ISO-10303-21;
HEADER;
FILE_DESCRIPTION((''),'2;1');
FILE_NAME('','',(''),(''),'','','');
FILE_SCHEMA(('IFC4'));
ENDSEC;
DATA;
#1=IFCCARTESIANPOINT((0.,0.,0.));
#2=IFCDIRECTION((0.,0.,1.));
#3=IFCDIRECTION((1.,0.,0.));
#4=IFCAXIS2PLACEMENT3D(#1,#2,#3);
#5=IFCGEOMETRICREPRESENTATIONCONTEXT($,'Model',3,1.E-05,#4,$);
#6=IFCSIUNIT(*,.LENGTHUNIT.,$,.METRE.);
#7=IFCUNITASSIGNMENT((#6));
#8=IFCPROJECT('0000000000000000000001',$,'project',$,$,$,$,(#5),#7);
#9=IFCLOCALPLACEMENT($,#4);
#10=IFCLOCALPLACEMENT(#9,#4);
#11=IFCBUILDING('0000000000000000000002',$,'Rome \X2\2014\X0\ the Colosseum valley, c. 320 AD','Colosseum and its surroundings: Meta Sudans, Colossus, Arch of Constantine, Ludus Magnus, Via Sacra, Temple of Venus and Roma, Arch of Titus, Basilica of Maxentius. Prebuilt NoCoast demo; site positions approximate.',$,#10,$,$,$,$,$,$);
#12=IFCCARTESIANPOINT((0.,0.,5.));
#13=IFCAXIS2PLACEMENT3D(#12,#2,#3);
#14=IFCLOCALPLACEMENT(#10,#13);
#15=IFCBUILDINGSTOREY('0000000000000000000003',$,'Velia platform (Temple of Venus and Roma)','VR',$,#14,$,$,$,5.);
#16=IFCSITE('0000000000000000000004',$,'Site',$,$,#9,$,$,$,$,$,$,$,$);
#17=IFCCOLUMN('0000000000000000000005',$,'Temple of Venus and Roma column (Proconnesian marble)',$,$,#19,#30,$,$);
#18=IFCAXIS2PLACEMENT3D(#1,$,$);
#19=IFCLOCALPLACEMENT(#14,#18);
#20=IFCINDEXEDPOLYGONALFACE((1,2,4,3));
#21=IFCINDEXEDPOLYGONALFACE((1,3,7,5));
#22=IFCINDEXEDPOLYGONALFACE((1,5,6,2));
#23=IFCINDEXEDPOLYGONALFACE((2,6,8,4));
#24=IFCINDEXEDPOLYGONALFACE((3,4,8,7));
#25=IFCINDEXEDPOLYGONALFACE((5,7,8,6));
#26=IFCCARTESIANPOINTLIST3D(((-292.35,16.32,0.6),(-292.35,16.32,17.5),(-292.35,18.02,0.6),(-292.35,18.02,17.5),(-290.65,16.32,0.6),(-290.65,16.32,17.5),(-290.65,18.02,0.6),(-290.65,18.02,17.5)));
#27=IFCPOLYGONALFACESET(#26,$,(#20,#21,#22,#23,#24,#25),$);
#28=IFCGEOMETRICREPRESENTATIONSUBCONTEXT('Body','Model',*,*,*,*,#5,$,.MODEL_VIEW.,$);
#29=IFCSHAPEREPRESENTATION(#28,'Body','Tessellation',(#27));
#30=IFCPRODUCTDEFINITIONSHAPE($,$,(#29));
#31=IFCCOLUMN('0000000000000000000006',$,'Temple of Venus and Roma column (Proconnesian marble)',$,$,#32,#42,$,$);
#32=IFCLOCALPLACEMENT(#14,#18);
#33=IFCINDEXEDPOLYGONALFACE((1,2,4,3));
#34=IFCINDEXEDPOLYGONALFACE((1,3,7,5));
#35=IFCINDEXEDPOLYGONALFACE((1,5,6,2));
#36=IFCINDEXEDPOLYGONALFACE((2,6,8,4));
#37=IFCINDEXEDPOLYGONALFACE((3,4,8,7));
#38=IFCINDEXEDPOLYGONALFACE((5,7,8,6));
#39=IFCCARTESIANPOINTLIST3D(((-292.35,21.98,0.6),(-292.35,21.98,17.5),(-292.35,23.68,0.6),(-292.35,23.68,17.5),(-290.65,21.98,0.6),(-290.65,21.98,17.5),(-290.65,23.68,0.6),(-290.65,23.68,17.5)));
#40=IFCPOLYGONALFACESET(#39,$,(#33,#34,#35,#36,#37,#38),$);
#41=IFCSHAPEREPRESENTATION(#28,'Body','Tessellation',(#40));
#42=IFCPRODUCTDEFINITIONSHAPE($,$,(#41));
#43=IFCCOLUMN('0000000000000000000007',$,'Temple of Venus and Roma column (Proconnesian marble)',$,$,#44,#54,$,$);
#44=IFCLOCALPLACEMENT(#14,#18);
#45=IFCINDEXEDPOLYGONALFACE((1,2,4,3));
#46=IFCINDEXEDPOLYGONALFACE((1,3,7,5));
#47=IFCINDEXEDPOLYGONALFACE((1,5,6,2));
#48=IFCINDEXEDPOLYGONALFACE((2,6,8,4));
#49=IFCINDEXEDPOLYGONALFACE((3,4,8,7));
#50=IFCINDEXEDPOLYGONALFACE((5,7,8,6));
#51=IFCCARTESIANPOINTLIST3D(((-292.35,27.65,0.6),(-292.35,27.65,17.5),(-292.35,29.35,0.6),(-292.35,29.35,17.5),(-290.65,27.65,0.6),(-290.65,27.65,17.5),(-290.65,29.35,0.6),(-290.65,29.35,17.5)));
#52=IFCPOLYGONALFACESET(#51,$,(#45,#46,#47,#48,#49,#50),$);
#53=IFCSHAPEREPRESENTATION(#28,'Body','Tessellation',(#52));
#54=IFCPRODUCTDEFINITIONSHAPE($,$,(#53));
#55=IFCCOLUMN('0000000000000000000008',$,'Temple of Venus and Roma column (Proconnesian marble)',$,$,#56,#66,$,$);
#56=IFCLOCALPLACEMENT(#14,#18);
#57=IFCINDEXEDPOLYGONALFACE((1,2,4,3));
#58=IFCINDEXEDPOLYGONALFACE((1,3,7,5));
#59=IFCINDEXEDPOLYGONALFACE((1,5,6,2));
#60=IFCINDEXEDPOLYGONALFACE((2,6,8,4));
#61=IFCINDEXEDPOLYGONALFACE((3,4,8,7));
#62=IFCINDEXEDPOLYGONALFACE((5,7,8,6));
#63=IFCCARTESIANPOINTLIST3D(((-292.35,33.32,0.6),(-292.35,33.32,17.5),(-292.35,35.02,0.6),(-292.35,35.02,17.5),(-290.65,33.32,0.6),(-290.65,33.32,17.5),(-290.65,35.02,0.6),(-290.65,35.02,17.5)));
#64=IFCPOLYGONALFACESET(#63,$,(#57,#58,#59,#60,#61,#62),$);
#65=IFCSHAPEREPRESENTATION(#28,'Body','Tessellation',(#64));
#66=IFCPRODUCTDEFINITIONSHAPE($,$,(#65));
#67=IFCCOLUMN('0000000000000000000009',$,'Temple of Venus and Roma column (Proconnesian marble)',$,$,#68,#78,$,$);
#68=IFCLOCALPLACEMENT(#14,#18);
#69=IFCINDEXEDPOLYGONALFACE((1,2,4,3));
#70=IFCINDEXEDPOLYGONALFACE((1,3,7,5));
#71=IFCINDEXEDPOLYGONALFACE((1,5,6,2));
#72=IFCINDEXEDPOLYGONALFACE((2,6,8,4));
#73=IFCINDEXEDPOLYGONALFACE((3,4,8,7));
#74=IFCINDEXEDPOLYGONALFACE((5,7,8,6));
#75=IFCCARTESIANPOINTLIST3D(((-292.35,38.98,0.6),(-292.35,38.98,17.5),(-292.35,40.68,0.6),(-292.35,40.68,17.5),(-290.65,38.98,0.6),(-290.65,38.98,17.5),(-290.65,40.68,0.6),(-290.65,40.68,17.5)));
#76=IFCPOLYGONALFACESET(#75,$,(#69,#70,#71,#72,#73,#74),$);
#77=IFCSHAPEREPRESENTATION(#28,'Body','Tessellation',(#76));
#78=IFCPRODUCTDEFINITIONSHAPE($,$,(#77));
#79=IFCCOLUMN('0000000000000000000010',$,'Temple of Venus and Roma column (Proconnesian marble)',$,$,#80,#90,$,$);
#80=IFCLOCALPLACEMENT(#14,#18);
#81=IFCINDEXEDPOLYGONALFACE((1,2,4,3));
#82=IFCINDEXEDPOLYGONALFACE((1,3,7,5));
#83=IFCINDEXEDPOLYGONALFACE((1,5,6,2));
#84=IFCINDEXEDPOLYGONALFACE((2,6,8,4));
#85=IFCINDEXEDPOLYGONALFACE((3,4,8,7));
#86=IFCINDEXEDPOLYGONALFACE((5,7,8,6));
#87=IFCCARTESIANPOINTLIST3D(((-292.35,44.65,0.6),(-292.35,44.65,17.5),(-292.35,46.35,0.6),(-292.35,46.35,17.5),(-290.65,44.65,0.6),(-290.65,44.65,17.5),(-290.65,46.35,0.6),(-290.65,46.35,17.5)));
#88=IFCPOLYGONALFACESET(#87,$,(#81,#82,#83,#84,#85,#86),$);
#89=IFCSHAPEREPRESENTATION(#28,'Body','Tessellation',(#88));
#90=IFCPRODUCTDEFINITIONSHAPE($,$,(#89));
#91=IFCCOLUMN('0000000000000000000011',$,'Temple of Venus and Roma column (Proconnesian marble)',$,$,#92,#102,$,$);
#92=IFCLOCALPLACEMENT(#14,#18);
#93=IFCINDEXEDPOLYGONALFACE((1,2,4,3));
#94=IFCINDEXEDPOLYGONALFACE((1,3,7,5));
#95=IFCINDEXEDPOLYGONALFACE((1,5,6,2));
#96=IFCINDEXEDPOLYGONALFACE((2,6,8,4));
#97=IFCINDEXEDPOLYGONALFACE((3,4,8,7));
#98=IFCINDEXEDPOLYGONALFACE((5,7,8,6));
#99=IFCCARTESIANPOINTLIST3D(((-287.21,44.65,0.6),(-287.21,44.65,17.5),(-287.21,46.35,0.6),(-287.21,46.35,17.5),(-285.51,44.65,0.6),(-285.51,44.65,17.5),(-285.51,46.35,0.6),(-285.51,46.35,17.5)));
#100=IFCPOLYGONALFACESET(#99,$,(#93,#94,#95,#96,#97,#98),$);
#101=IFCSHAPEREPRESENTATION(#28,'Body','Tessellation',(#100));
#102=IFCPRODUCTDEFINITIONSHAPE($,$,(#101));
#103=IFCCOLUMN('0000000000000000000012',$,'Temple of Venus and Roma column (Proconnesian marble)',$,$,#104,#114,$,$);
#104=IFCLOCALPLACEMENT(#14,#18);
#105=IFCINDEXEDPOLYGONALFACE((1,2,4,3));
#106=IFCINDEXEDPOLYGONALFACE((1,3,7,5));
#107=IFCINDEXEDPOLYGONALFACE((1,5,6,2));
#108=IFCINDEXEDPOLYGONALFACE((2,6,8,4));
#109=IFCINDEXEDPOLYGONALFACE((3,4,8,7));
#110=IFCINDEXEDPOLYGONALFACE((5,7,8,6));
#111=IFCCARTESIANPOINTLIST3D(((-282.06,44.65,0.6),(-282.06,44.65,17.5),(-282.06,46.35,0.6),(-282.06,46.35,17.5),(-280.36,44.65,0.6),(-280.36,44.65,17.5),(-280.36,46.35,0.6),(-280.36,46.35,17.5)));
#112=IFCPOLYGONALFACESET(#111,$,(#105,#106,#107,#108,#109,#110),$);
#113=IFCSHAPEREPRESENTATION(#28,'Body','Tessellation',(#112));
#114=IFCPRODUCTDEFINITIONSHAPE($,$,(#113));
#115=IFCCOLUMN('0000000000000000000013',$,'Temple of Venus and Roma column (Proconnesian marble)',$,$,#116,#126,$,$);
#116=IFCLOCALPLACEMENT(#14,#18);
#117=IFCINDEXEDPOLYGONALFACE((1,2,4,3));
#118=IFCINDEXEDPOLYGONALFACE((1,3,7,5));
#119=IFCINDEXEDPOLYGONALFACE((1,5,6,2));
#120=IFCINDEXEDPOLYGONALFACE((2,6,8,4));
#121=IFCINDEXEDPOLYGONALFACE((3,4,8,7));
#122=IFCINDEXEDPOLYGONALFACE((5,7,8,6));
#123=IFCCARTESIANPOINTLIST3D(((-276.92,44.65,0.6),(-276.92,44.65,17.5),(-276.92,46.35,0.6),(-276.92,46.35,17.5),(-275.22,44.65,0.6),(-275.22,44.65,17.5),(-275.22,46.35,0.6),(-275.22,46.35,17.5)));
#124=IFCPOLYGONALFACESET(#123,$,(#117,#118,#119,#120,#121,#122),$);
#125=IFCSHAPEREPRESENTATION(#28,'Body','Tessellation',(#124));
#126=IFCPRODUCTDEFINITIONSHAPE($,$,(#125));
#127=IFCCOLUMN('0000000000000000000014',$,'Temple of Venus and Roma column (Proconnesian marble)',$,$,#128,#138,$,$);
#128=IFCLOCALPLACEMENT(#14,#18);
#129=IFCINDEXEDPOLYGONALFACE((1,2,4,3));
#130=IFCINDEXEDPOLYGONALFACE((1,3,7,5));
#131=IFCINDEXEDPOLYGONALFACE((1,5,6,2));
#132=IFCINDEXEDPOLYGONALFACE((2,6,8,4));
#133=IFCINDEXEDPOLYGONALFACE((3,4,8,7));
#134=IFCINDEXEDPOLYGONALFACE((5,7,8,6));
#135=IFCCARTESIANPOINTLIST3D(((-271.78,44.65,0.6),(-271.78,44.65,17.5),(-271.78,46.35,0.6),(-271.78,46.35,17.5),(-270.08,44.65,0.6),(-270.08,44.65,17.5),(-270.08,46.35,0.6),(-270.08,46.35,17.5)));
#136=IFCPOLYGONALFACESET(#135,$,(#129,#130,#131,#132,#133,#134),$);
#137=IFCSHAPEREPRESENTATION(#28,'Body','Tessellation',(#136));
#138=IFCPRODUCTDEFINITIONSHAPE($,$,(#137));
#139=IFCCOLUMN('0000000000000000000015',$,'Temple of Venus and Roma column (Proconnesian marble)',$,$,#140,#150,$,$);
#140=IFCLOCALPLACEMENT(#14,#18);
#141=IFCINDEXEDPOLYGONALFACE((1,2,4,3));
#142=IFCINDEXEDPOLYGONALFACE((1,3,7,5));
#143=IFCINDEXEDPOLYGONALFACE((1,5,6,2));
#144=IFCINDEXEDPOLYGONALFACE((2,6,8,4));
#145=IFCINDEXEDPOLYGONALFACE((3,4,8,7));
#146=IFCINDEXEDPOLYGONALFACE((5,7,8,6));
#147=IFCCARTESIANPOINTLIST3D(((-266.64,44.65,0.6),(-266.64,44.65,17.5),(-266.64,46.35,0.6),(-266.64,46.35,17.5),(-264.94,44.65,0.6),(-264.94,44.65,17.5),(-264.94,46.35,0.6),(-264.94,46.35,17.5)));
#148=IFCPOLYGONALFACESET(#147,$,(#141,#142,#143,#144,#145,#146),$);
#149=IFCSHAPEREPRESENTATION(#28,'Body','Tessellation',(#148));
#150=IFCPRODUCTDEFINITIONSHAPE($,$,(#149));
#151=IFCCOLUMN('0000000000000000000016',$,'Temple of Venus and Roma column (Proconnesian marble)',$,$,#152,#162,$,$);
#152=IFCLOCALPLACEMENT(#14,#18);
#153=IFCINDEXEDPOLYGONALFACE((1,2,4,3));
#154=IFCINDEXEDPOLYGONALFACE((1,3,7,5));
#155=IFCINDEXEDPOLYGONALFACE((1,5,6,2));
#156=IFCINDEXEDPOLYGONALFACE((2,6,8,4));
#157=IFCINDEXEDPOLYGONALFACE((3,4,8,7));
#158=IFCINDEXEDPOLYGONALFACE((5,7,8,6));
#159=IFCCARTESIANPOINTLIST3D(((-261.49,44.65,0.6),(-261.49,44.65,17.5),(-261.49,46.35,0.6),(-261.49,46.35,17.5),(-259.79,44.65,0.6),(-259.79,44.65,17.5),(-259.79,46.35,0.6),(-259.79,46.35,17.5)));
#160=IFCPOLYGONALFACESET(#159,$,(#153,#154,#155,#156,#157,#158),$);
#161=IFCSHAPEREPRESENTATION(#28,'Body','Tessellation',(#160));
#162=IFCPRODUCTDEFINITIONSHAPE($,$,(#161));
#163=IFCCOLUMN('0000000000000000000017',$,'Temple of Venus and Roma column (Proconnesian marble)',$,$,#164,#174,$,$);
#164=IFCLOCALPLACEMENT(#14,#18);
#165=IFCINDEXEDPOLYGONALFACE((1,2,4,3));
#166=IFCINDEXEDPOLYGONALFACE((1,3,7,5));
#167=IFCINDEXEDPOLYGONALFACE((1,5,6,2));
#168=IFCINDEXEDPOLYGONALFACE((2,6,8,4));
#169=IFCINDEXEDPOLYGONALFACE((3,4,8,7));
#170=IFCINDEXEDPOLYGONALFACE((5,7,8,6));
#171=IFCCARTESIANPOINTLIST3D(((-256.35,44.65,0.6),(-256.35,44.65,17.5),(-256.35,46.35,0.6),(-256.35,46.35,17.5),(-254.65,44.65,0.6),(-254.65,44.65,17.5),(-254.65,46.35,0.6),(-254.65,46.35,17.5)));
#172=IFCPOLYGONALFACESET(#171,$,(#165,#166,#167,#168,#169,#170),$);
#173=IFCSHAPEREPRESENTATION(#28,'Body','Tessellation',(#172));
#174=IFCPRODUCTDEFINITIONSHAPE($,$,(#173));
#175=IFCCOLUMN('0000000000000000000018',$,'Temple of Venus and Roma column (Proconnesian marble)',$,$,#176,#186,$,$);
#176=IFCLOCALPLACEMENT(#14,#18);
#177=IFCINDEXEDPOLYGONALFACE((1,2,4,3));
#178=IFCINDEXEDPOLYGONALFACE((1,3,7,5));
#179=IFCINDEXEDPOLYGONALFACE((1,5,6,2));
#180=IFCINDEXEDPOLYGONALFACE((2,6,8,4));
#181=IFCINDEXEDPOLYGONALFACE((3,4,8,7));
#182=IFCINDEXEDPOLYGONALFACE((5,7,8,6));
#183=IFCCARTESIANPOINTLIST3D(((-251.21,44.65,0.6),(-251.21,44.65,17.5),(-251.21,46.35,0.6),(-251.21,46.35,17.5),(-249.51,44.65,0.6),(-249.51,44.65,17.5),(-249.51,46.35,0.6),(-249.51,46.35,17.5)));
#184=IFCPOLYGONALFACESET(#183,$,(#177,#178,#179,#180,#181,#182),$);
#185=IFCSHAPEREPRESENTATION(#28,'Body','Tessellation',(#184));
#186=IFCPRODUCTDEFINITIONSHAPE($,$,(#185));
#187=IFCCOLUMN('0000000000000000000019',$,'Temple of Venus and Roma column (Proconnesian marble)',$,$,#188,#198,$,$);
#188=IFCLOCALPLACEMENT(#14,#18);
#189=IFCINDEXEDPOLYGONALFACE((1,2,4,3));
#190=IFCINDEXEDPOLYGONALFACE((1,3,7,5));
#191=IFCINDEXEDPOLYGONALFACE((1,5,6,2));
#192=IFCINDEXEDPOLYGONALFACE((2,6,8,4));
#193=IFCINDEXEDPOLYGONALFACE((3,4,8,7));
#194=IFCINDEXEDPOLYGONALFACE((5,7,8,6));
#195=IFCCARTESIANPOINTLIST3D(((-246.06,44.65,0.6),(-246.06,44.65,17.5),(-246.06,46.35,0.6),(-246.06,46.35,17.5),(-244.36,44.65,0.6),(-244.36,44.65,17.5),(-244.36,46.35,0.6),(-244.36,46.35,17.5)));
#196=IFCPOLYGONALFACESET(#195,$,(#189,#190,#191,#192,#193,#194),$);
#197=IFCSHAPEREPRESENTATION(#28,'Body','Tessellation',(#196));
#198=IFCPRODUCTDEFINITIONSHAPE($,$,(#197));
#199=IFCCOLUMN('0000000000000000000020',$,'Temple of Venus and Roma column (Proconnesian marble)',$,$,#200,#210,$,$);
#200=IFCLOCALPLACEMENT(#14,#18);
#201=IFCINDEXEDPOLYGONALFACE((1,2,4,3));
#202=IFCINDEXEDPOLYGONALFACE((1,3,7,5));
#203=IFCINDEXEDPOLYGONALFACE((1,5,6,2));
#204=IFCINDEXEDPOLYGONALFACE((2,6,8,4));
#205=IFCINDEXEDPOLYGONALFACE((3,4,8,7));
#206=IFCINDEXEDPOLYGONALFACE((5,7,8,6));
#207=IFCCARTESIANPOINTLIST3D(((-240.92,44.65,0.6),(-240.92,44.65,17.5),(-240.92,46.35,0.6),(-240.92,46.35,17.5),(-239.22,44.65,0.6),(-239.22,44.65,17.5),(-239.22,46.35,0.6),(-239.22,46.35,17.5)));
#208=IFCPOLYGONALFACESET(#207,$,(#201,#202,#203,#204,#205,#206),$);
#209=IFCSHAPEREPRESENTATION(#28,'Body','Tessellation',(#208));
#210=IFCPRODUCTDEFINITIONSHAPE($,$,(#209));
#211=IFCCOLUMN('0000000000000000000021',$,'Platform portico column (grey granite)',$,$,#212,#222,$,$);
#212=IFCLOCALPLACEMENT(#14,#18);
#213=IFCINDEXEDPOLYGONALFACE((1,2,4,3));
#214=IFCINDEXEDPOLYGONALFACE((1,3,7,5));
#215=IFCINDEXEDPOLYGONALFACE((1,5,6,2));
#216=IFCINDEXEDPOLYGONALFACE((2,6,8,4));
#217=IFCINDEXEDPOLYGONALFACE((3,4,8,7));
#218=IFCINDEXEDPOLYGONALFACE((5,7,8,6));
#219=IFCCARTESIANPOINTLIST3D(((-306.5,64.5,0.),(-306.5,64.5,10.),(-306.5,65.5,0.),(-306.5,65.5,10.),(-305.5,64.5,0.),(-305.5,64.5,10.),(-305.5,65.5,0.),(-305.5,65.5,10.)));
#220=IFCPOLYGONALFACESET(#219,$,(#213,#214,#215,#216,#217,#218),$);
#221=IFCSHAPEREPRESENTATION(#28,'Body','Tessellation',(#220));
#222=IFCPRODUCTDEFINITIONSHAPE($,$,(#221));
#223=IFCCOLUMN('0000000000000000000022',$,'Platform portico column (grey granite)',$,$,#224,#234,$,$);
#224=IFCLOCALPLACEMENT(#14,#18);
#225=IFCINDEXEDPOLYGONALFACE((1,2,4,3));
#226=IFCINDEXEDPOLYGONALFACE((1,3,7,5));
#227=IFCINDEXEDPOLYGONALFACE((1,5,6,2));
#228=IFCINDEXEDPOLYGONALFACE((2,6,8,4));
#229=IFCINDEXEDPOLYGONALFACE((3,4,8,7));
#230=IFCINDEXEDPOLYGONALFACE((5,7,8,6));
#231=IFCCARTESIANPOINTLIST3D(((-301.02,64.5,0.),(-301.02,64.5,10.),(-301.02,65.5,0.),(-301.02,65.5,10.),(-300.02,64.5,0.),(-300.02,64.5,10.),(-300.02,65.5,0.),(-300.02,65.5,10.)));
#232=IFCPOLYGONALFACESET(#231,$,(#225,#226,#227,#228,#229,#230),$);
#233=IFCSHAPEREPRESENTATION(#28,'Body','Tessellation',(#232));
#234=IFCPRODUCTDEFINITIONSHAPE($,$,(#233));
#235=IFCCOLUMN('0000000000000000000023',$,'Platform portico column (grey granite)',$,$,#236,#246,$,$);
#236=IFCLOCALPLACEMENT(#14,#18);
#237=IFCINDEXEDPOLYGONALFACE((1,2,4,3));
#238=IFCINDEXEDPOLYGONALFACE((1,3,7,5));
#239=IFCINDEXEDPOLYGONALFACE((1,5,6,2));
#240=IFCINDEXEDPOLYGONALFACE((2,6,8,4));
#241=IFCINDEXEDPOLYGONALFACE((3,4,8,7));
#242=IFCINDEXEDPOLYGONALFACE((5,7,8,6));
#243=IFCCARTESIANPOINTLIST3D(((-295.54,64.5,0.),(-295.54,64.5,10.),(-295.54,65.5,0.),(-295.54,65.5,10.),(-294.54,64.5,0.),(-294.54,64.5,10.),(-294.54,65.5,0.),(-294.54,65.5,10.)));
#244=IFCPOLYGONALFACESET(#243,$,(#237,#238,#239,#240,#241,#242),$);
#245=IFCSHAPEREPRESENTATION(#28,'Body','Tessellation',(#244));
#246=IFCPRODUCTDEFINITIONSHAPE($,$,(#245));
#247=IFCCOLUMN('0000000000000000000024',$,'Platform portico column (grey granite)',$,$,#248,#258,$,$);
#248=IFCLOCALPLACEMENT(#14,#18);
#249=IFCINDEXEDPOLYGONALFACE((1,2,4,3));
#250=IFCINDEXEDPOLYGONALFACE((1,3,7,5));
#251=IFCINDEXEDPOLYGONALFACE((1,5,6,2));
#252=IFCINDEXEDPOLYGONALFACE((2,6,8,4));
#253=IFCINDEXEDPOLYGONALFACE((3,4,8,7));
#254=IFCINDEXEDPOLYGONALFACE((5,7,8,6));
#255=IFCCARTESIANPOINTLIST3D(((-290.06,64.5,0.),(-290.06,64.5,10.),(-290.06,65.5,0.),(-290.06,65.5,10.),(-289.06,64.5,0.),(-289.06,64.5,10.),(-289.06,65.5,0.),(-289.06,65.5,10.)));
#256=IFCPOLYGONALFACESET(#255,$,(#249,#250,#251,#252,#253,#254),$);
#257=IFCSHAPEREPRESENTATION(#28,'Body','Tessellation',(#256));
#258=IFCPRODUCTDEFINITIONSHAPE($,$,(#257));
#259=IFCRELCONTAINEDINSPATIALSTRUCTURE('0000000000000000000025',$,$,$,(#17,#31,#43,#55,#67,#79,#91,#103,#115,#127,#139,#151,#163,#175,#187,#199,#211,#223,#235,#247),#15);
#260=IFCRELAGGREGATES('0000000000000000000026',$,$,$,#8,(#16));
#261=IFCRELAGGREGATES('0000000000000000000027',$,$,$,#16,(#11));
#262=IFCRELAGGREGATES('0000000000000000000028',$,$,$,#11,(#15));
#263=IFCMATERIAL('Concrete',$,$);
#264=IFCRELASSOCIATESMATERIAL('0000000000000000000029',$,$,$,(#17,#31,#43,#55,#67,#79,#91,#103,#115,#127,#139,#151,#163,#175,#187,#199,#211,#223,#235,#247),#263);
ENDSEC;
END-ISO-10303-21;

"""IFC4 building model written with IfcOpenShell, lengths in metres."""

from ifc_helpers import new_model, si_unit, frame, origin_with_axes, place, context, subcontext, project, spatial, indexed_curve, outline, extrude, material, element, save


model = new_model("IFC4")

# Units and contexts
model_context = context("Model", 3, precision=1e-05, world=origin_with_axes())
body_context = subcontext(model_context, "Body", "Model", "MODEL_VIEW")
ifc_project = project(units=[si_unit("LENGTHUNIT", "METRE")], contexts=[model_context])

# Site, building, storey
site_placement = place(None, origin_with_axes())
site = spatial("IfcSite", under=ifc_project, at=site_placement, Name="Site")
building_placement = place(site_placement, origin_with_axes())
building = spatial("IfcBuilding", under=site, at=building_placement, Name="Rome — the Colosseum valley, c. 320 AD", Description="Colosseum and its surroundings: Meta Sudans, Colossus, Arch of Constantine, Ludus Magnus, Via Sacra, Temple of Venus and Roma, Arch of Titus, Basilica of Maxentius. Prebuilt NoCoast demo; site positions approximate.")
storey_placement = place(building_placement, frame((0.0, 0.0, 5.0), z_axis=(0.0, 0.0, 1.0), x_axis=(1.0, 0.0, 0.0)))
storey = spatial("IfcBuildingStorey", under=building, at=storey_placement, Name="Velia platform (Temple of Venus and Roma)", Description="VR", Elevation=5.0)

# Columns
ifc_material_1 = material(Name="Concrete")
for number, where, z_axis, x_axis, name in (
    (1, (-292.35, 17.17, 0.6), (0.0, 0.0, 1.0), (1.0, 0.0, 0.0), "Temple of Venus and Roma column (Proconnesian marble)"),
    (2, (-292.35, 22.83, 0.6), (0.0, 0.0, 1.0), (1.0, 0.0, 0.0), "Temple of Venus and Roma column (Proconnesian marble)"),
    (3, (-292.35, 28.5, 0.6), (0.0, 0.0, 1.0), (1.0, 0.0, 0.0), "Temple of Venus and Roma column (Proconnesian marble)"),
    (4, (-292.35, 34.17, 0.6), (0.0, 0.0, 1.0), (1.0, 0.0, 0.0), "Temple of Venus and Roma column (Proconnesian marble)"),
    (5, (-292.35, 39.83, 0.6), (0.0, 0.0, 1.0), (1.0, 0.0, 0.0), "Temple of Venus and Roma column (Proconnesian marble)"),
    (6, (-292.35, 45.5, 0.6), (0.0, 0.0, 1.0), (1.0, 0.0, 0.0), "Temple of Venus and Roma column (Proconnesian marble)"),
    (7, (-287.21, 45.5, 0.6), (0.0, 0.0, 1.0), (1.0, 0.0, 0.0), "Temple of Venus and Roma column (Proconnesian marble)"),
    (8, (-282.06, 45.5, 0.6), (0.0, 0.0, 1.0), (1.0, 0.0, 0.0), "Temple of Venus and Roma column (Proconnesian marble)"),
    (9, (-276.92, 45.5, 0.6), (0.0, 0.0, 1.0), (1.0, 0.0, 0.0), "Temple of Venus and Roma column (Proconnesian marble)"),
    (10, (-271.78, 45.5, 0.6), (0.0, 0.0, 1.0), (1.0, 0.0, 0.0), "Temple of Venus and Roma column (Proconnesian marble)"),
    (11, (-266.64, 45.5, 0.6), (0.0, 0.0, 1.0), (1.0, 0.0, 0.0), "Temple of Venus and Roma column (Proconnesian marble)"),
    (12, (-261.49, 45.5, 0.6), (0.0, 0.0, 1.0), (1.0, 0.0, 0.0), "Temple of Venus and Roma column (Proconnesian marble)"),
    (13, (-256.35, 45.5, 0.6), (0.0, 0.0, 1.0), (1.0, 0.0, 0.0), "Temple of Venus and Roma column (Proconnesian marble)"),
    (14, (-251.21, 45.5, 0.6), (0.0, 0.0, 1.0), (1.0, 0.0, 0.0), "Temple of Venus and Roma column (Proconnesian marble)"),
    (15, (-246.06, 45.5, 0.6), (0.0, 0.0, 1.0), (1.0, 0.0, 0.0), "Temple of Venus and Roma column (Proconnesian marble)"),
    (16, (-240.92, 45.5, 0.6), (0.0, 0.0, 1.0), (1.0, 0.0, 0.0), "Temple of Venus and Roma column (Proconnesian marble)"),
):
    element("IfcColumn", number, at=place(storey_placement, frame(where, z_axis=z_axis, x_axis=x_axis)), inside=storey, material=ifc_material_1, Name=name, context=body_context, shape_type="SweptSolid", body=[
        extrude(outline(indexed_curve([(0.0, 0.0), (0.0, 1.7), (1.7, 1.7), (1.7, 0.0), (0.0, 0.0)], self_intersect=False)), frame((0.0, -0.85, 0.0), z_axis=(0.0, 0.0, 1.0), x_axis=(1.0, 0.0, 0.0)), (0.0, 0.0, 1.0), 16.9),
    ])
for number, where, z_axis, x_axis, name in (
    (17, (-306.5, 65.0, 0.0), (0.0, 0.0, 1.0), (1.0, 0.0, 0.0), "Platform portico column (grey granite)"),
    (18, (-301.02, 65.0, 0.0), (0.0, 0.0, 1.0), (1.0, 0.0, 0.0), "Platform portico column (grey granite)"),
    (19, (-295.54, 65.0, 0.0), (0.0, 0.0, 1.0), (1.0, 0.0, 0.0), "Platform portico column (grey granite)"),
    (20, (-290.06, 65.0, 0.0), (0.0, 0.0, 1.0), (1.0, 0.0, 0.0), "Platform portico column (grey granite)"),
):
    element("IfcColumn", number, at=place(storey_placement, frame(where, z_axis=z_axis, x_axis=x_axis)), inside=storey, material=ifc_material_1, Name=name, context=body_context, shape_type="SweptSolid", body=[
        extrude(outline(indexed_curve([(0.0, 0.0), (0.0, 1.0), (1.0, 1.0), (1.0, 0.0), (0.0, 0.0)], self_intersect=False)), frame((0.0, -0.5, 0.0), z_axis=(0.0, 0.0, 1.0), x_axis=(1.0, 0.0, 0.0)), (0.0, 0.0, 1.0), 10.0),
    ])

save(model, "model.ifc")
